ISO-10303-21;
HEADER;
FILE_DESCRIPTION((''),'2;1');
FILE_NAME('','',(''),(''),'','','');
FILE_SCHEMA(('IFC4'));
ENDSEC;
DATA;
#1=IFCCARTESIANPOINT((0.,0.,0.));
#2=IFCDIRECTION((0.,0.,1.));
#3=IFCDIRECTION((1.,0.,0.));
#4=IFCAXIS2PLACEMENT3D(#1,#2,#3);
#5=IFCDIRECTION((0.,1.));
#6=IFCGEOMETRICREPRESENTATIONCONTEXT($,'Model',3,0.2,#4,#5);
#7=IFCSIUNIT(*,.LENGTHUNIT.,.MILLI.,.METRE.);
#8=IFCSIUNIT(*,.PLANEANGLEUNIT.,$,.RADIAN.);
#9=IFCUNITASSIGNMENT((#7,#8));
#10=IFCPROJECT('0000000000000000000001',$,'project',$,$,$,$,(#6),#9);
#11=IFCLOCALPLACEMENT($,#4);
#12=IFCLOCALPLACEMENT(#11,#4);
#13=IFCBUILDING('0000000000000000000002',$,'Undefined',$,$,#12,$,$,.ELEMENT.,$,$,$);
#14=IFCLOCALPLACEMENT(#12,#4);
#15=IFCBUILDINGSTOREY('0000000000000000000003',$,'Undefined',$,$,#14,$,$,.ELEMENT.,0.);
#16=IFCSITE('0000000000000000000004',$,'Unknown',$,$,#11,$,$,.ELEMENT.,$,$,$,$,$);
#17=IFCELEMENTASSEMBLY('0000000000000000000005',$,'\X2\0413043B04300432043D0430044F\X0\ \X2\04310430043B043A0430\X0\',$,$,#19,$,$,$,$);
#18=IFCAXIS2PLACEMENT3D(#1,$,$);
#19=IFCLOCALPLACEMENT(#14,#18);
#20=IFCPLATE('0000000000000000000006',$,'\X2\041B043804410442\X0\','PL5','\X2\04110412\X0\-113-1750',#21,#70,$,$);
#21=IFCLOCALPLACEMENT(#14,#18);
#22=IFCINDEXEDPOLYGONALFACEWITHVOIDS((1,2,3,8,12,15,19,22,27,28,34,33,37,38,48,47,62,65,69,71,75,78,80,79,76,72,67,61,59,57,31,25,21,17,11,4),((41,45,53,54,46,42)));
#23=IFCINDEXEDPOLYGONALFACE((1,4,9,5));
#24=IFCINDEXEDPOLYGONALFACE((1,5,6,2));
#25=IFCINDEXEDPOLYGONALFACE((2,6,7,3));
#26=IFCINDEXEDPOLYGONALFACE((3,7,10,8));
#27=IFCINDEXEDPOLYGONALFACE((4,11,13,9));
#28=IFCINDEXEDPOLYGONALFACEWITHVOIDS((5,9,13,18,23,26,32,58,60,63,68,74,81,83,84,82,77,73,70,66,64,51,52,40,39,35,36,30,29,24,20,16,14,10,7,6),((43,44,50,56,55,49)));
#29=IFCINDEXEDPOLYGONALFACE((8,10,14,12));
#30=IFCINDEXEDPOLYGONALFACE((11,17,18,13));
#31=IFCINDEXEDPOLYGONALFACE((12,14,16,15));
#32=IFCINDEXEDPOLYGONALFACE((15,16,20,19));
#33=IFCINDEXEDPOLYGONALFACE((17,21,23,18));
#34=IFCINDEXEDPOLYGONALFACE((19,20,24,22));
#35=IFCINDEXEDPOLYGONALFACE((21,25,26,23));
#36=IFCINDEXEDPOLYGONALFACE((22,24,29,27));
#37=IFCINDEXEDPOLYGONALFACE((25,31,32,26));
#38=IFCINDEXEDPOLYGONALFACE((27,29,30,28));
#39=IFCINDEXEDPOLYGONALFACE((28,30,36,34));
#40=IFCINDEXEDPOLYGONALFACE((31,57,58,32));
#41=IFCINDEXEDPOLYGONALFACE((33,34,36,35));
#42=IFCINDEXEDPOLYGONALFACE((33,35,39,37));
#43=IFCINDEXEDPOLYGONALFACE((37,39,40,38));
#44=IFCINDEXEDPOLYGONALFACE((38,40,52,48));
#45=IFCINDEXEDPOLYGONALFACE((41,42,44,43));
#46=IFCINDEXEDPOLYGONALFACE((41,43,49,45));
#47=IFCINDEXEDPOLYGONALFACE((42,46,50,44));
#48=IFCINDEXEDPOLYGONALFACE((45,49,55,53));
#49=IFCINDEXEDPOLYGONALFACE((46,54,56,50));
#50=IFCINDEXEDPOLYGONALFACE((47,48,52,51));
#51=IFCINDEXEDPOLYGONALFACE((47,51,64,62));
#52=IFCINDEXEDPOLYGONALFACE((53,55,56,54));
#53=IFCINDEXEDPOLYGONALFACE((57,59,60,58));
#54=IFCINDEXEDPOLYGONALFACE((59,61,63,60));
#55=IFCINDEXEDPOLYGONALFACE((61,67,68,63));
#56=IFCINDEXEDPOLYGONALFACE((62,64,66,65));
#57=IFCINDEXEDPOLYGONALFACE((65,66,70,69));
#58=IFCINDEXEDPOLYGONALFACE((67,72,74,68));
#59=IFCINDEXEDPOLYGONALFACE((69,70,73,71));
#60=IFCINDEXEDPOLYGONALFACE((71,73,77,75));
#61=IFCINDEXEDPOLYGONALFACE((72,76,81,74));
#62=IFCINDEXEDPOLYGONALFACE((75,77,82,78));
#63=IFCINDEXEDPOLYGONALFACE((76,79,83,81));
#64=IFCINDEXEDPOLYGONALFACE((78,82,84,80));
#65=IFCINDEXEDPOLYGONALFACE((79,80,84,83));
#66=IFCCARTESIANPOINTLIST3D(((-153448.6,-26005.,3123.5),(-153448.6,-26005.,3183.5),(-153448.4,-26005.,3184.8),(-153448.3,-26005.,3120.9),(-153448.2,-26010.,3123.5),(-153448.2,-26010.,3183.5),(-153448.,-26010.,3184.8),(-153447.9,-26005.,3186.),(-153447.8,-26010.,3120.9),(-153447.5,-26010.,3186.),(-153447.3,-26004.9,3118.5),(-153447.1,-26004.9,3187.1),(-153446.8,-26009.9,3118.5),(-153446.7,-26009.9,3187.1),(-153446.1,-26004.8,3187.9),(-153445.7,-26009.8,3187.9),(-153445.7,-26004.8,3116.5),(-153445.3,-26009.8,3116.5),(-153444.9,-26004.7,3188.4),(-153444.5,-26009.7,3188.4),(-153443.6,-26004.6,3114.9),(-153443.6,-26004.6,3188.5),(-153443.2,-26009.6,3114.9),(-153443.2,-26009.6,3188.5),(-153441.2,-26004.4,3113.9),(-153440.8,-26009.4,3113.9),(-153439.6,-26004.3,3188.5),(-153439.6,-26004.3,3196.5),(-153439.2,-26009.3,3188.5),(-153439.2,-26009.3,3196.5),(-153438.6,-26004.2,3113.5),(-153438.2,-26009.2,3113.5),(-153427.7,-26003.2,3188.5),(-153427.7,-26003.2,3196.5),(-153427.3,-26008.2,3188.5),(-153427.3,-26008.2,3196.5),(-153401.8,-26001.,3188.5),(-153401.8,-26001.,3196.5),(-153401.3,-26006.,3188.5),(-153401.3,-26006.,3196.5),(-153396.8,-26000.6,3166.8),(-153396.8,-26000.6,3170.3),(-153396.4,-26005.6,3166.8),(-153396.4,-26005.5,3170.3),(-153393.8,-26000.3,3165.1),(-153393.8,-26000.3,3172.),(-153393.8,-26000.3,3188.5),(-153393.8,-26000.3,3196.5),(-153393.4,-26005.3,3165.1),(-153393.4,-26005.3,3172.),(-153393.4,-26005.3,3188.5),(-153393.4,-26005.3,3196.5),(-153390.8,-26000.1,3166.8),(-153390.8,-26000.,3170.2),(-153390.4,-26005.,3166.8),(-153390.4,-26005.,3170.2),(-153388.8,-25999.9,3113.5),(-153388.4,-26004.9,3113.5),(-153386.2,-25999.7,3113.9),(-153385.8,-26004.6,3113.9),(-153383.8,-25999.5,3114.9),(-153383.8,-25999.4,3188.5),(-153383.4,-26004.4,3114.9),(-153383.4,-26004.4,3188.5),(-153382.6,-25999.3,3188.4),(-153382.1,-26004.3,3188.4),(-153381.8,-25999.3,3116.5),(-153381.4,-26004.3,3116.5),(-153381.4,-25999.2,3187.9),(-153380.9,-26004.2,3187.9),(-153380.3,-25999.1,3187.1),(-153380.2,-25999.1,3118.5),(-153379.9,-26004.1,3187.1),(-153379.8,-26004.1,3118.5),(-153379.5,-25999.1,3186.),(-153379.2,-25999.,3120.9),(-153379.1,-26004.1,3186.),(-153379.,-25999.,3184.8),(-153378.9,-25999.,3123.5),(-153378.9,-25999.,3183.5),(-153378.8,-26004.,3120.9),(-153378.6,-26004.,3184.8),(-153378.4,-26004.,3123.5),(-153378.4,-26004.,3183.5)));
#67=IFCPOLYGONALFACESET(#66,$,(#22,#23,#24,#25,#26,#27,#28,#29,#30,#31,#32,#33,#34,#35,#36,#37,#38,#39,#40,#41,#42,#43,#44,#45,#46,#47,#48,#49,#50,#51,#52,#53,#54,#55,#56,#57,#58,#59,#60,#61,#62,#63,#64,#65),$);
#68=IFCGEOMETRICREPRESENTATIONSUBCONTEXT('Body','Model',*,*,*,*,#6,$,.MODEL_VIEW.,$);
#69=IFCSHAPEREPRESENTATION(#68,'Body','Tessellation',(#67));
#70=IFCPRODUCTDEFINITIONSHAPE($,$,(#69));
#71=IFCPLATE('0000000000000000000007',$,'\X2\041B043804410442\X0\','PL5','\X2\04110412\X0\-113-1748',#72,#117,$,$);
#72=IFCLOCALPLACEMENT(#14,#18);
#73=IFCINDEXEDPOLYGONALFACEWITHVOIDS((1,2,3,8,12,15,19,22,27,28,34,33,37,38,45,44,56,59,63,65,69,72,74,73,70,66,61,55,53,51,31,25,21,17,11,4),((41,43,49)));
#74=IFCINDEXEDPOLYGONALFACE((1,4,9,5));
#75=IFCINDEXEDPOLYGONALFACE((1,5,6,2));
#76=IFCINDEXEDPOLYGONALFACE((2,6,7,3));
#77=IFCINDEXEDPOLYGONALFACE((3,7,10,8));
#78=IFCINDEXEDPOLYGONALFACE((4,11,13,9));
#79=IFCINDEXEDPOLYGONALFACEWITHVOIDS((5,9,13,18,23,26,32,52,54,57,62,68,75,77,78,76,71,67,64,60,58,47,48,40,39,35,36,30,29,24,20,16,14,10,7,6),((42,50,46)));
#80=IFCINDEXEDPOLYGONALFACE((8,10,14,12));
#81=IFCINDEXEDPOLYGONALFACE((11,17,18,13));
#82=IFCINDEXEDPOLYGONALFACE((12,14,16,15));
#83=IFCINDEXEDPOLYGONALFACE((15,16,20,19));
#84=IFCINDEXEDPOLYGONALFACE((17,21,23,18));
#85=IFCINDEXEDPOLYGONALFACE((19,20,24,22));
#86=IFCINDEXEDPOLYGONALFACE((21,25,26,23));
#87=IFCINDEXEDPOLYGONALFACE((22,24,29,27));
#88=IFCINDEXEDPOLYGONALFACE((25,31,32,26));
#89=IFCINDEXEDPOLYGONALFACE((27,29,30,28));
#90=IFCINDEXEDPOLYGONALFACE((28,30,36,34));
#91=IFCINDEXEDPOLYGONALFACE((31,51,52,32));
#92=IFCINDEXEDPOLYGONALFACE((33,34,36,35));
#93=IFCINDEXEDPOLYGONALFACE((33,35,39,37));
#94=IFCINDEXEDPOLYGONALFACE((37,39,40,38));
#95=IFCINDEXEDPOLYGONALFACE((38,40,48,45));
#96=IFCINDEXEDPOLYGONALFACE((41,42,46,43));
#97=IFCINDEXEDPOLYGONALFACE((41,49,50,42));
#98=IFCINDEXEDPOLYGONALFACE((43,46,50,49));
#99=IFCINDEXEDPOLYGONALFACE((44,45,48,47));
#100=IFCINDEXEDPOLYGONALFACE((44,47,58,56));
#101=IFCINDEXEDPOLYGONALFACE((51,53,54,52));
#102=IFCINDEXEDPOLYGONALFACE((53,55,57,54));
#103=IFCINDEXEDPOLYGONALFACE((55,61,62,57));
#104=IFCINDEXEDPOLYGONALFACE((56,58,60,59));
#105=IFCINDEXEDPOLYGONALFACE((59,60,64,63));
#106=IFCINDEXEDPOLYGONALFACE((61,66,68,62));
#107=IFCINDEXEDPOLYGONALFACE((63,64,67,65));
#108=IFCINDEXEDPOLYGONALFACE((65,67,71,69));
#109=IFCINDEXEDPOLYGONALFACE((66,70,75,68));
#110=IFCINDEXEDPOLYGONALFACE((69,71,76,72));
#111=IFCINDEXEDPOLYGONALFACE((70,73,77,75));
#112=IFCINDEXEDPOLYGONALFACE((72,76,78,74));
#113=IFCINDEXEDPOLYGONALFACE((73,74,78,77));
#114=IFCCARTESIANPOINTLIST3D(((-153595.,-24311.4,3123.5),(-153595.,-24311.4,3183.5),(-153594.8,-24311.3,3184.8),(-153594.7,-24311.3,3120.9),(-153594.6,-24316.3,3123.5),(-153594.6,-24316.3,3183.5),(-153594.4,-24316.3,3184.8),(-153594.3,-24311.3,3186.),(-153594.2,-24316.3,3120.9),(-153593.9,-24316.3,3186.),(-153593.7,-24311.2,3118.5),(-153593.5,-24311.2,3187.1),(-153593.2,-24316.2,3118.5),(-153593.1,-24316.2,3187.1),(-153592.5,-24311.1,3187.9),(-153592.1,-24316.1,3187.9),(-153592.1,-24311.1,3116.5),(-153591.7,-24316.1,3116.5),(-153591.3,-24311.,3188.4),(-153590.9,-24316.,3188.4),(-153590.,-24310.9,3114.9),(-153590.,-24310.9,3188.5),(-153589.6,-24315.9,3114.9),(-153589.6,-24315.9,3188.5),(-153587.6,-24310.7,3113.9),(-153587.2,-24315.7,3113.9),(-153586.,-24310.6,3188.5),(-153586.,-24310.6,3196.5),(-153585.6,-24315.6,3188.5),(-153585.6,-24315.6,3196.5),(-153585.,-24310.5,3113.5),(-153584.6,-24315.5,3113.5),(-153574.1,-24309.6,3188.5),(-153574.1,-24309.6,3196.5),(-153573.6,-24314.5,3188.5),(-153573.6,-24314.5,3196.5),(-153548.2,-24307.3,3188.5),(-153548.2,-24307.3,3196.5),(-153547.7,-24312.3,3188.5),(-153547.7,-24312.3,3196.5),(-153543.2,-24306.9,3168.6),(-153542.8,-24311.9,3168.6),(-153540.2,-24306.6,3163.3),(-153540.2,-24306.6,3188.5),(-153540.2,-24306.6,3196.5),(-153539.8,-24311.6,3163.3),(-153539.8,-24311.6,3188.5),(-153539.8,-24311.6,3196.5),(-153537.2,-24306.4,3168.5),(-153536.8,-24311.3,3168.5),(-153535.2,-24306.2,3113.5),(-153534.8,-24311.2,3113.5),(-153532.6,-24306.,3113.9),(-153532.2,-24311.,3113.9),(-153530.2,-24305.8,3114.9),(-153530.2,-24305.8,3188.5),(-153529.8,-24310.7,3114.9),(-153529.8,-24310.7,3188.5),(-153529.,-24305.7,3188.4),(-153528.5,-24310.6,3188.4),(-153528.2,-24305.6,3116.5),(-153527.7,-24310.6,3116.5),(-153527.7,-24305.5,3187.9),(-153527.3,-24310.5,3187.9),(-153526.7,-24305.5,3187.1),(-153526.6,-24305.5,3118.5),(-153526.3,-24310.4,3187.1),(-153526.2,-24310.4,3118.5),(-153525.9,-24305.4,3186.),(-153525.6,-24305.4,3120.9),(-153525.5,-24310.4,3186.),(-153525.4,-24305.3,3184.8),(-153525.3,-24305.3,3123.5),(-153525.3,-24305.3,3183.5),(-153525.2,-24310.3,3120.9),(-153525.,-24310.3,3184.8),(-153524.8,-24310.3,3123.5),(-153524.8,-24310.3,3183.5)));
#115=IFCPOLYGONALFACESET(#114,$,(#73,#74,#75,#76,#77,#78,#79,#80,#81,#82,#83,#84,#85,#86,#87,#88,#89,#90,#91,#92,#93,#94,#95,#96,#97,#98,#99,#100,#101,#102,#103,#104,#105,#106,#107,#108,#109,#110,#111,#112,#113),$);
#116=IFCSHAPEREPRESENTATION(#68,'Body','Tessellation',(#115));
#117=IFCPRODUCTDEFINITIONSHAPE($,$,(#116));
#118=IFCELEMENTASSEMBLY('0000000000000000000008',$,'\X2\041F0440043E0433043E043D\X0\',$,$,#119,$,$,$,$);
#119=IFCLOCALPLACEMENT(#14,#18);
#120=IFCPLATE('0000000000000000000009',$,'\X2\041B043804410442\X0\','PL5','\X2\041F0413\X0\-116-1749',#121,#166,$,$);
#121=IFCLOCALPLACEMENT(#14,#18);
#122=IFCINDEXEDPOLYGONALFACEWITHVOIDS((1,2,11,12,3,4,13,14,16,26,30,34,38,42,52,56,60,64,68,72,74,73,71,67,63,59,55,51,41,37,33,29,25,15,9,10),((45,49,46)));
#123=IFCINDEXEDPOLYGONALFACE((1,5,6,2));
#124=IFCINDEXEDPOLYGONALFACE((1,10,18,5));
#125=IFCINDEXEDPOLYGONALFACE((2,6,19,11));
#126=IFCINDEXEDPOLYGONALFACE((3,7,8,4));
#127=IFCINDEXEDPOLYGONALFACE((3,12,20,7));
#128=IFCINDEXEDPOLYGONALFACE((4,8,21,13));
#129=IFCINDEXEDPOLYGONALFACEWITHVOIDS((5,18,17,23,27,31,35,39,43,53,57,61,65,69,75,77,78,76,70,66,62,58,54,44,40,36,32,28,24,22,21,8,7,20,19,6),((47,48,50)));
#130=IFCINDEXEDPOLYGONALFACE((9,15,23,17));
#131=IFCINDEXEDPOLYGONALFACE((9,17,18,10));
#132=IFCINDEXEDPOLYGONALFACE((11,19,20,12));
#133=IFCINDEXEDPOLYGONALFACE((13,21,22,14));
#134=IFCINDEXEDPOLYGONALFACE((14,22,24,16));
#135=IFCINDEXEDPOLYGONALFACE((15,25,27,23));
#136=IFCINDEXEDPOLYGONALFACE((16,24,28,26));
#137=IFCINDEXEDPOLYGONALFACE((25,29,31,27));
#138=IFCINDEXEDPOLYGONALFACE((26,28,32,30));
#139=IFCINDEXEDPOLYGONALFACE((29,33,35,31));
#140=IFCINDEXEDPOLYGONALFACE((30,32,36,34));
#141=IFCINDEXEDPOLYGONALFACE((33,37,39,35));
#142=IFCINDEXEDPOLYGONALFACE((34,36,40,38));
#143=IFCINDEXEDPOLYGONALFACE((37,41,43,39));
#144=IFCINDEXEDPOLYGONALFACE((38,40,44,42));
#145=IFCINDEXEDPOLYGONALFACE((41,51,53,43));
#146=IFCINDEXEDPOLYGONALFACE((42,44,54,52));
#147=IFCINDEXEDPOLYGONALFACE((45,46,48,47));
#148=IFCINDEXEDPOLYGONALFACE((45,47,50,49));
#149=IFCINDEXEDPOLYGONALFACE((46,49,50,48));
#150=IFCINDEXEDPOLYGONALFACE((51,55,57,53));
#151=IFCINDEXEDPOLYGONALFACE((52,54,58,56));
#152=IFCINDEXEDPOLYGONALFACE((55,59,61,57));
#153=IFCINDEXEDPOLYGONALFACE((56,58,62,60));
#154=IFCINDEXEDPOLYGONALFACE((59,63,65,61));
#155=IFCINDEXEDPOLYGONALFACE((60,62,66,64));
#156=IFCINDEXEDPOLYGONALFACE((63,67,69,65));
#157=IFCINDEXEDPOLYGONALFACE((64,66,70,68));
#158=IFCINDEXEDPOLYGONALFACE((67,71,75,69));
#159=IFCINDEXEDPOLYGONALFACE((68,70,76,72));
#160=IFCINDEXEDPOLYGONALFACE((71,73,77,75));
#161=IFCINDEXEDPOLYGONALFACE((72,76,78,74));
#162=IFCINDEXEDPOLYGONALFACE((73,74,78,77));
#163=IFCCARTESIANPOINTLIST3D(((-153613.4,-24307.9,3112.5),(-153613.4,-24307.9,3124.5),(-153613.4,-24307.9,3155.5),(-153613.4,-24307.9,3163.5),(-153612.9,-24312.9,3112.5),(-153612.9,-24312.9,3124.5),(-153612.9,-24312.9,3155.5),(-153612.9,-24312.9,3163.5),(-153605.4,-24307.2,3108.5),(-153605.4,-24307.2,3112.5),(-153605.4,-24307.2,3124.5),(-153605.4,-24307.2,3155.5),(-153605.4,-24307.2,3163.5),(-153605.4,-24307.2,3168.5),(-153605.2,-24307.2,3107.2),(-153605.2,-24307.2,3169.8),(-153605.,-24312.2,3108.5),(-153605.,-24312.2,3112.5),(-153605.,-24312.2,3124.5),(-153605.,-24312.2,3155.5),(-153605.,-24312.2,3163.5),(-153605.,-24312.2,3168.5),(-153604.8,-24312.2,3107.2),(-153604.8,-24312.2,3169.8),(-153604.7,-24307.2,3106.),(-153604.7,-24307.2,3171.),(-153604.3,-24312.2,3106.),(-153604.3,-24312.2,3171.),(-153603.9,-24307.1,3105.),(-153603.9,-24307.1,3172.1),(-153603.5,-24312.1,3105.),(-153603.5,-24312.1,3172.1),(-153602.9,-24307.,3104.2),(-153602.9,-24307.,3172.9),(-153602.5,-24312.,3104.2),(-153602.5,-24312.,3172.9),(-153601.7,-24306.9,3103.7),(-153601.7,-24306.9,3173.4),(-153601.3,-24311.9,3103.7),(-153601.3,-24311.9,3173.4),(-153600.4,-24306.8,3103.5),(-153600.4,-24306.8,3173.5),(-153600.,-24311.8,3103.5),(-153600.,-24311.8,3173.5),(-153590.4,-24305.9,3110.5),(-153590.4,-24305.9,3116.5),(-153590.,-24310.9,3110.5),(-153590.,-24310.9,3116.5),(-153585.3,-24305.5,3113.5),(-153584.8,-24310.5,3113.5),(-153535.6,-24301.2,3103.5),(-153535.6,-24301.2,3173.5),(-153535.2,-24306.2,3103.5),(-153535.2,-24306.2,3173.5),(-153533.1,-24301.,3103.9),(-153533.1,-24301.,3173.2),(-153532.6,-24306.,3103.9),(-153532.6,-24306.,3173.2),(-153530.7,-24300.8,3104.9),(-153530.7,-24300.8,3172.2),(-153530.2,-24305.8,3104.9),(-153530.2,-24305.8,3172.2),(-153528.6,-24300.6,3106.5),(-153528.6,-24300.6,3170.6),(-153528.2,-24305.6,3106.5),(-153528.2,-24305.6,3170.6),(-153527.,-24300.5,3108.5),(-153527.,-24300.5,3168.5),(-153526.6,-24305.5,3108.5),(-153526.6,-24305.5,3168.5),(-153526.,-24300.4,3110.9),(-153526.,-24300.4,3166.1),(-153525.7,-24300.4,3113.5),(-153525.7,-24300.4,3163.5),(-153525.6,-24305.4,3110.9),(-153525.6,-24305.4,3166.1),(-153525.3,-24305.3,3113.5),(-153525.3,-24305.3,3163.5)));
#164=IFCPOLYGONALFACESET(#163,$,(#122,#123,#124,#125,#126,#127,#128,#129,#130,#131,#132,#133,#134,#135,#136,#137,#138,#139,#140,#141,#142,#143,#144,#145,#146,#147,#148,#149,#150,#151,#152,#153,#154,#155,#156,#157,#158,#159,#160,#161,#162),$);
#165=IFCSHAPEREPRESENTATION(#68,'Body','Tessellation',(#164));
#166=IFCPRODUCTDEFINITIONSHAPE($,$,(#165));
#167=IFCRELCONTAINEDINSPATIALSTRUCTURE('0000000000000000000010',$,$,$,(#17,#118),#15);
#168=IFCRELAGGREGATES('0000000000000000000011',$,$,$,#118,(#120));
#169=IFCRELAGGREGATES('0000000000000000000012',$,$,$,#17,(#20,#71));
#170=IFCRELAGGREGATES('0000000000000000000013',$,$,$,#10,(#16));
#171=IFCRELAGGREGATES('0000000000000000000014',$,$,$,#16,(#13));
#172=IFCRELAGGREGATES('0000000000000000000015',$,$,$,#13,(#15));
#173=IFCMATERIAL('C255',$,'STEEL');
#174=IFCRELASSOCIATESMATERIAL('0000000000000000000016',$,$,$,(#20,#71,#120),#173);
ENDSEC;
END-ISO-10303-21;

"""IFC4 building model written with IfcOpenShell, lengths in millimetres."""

from ifc_helpers import new_model, si_unit, direction, frame, origin_with_axes, place, context, subcontext, project, spatial, line, arc, indexed_curve, outline, extrude, material, element, aggregate, save


model = new_model("IFC4")

# Units and contexts
model_context = context("Model", 3, precision=0.2, world=origin_with_axes(), true_north=direction((0.0, 1.0)))
body_context = subcontext(model_context, "Body", "Model", "MODEL_VIEW")
ifc_project = project(units=[si_unit("LENGTHUNIT", "METRE", prefix="MILLI"), si_unit("PLANEANGLEUNIT", "RADIAN")], contexts=[model_context])

# Site, building, storey
site_placement = place(None, origin_with_axes())
site = spatial("IfcSite", under=ifc_project, at=site_placement, Name="Unknown", CompositionType="ELEMENT")
building_placement = place(site_placement, origin_with_axes())
building = spatial("IfcBuilding", under=site, at=building_placement, Name="Undefined", CompositionType="ELEMENT")
storey_placement = place(building_placement, origin_with_axes())
storey = spatial("IfcBuildingStorey", under=building, at=storey_placement, Name="Undefined", CompositionType="ELEMENT", Elevation=0.0)

# Shared definitions
ifc_material_1 = material(Name="C255", Category="STEEL")

# Element assemblies, plates, voiding features
assembly_1_placement = place(storey_placement, frame((-153409.2, -26112.7, 3248.5), z_axis=(-0.996285, -0.086114, -0.000024), x_axis=(-0.086114, 0.996285, 0.0)))
assembly_1 = element("IfcElementAssembly", 1, at=assembly_1_placement, inside=storey, Name="Главная балка")
plate_1_placement = place(assembly_1_placement, frame((108.2, 135.0, -40.0), z_axis=(1.0, 0.000054, 0.0), x_axis=(0.0, -0.000054, 1.0)))
plate_1 = element("IfcPlate", 2, at=plate_1_placement, material=ifc_material_1, Name="Лист", Description="PL5", ObjectType="БВ-113-1750", context=body_context, shape_type="SolidModel", body=[
    extrude(outline(indexed_curve([(0.0, 10.0), (2.9, 2.9), (10.0, 0.0), (60.0, 0.0), (67.1, 2.9), (70.0, 10.0), (70.0, 70.0), (68.5, 73.5), (65.0, 75.0), (61.0, 75.0), (61.0, 83.0), (49.0, 83.0), (49.0, 75.0), (23.0, 75.0), (23.0, 83.0), (15.0, 83.0), (15.0, 75.0), (5.0, 75.0), (1.5, 73.5), (0.0, 70.0)], segments=[arc(1, 2, 3), line(3, 4), arc(4, 5, 6), line(6, 7), arc(7, 8, 9), line(9, 10, 11, 12, 13, 14, 15, 16, 17, 18), arc(18, 19, 20), line(20, 1)])), frame((0.0, 0.0, 2.5), z_axis=(0.0, 0.0, 1.0), x_axis=(1.0, 0.0, 0.0)), (0.0, 0.0, -1.0), 5.0),
])
voiding_feature_1_placement = place(plate_1_placement, frame((15.0, 55.0, 10.0), z_axis=(0.007997, -0.999968, -0.000026), x_axis=(0.0, 0.000026, -1.0)))
element("IfcVoidingFeature", 3, at=voiding_feature_1_placement, cuts=plate_1, Name="Балка", ObjectType="(?)", PredefinedType="HOLE", context=body_context, shape_type="SolidModel", body=[
    extrude(outline(indexed_curve([(1.7, -3.0), (3.5, 0.0), (1.7, 3.0), (-1.7, 3.0), (-3.5, 0.0), (-1.7, -3.0)], segments=[line(1, 2, 3, 4, 5, 6, 1)])), frame((0.0, 0.0, 0.0), z_axis=(-1.0, 0.0, 0.0), x_axis=(0.0, 0.0, 1.0)), (0.0, 0.0, -1.0), 20.0),
])
plate_2_placement = place(assembly_1_placement, frame((1808.2, 135.0, -40.0), z_axis=(1.0, 0.000054, 0.0), x_axis=(0.0, -0.000054, 1.0)))
plate_2 = element("IfcPlate", 4, at=plate_2_placement, material=ifc_material_1, Name="Лист", Description="PL5", ObjectType="БВ-113-1748", context=body_context, shape_type="SolidModel", body=[
    extrude(outline(indexed_curve([(0.0, 10.0), (2.9, 2.9), (10.0, 0.0), (60.0, 0.0), (67.1, 2.9), (70.0, 10.0), (70.0, 70.0), (68.5, 73.5), (65.0, 75.0), (61.0, 75.0), (61.0, 83.0), (49.0, 83.0), (49.0, 75.0), (23.0, 75.0), (23.0, 83.0), (15.0, 83.0), (15.0, 75.0), (5.0, 75.0), (1.5, 73.5), (0.0, 70.0)], segments=[arc(1, 2, 3), line(3, 4), arc(4, 5, 6), line(6, 7), arc(7, 8, 9), line(9, 10, 11, 12, 13, 14, 15, 16, 17, 18), arc(18, 19, 20), line(20, 1)])), frame((0.0, 0.0, 2.5), z_axis=(0.0, 0.0, 1.0), x_axis=(1.0, 0.0, 0.0)), (0.0, 0.0, -1.0), 5.0),
])
voiding_feature_2_placement = place(plate_2_placement, frame((15.0, 55.0, 10.0), z_axis=(0.007997, -0.999968, -0.000026), x_axis=(0.0, 0.000026, -1.0)))
element("IfcVoidingFeature", 5, at=voiding_feature_2_placement, cuts=plate_2, Name="Балка", ObjectType="(?)", PredefinedType="HOLE", context=body_context, shape_type="SolidModel", body=[
    extrude(outline(indexed_curve([(0.0, -3.0), (5.2, 0.0), (0.0, 3.0)], segments=[line(1, 2, 3, 1)])), frame((0.0, 0.0, 0.0), z_axis=(-1.0, 0.0, 0.0), x_axis=(0.0, 0.0, 1.0)), (0.0, 0.0, -1.0), 20.0),
])
assembly_2_placement = place(storey_placement, frame((-153645.0, -24313.2, 533.0), z_axis=(0.086114, -0.996285, 0.0), x_axis=(0.0, 0.0, 1.0)))
assembly_2 = element("IfcElementAssembly", 6, at=assembly_2_placement, inside=storey, Name="Прогон")
plate_3_placement = place(assembly_2_placement, frame((2640.5, -120.0, 0.0), z_axis=(0.0, -0.000057, -1.0), x_axis=(-1.0, 0.000024, 0.0)))
plate_3 = element("IfcPlate", 7, at=plate_3_placement, material=ifc_material_1, Name="Лист", Description="PL5", ObjectType="ПГ-116-1749", context=body_context, shape_type="SolidModel", body=[
    extrude(outline(indexed_curve([(0.0, 10.0), (2.9, 2.9), (10.0, 0.0), (60.0, 0.0), (67.1, 2.9), (70.0, 10.0), (70.0, 75.0), (68.5, 78.5), (65.0, 80.0), (61.0, 80.0), (61.0, 88.0), (49.0, 88.0), (49.0, 80.0), (18.0, 80.0), (18.0, 88.0), (10.0, 88.0), (10.0, 80.0), (5.0, 80.0), (1.5, 78.5), (0.0, 75.0)], segments=[arc(1, 2, 3), line(3, 4), arc(4, 5, 6), line(6, 7), arc(7, 8, 9), line(9, 10, 11, 12, 13, 14, 15, 16, 17, 18), arc(18, 19, 20), line(20, 1)])), frame((0.0, 0.0, 2.5), z_axis=(0.0, 0.0, 1.0), x_axis=(1.0, 0.0, 0.0)), (0.0, 0.0, -1.0), 5.0),
])
voiding_feature_3_placement = place(plate_3_placement, frame((60.0, 65.0, 6.0), z_axis=(-0.000054, -1.0, 0.000034), x_axis=(0.0, -0.000034, -1.0)))
element("IfcVoidingFeature", 8, at=voiding_feature_3_placement, cuts=plate_3, Name="Балка", ObjectType="(?)", PredefinedType="HOLE", context=body_context, shape_type="SolidModel", body=[
    extrude(outline(indexed_curve([(0.0, -3.0), (5.2, 0.0), (0.0, 3.0)], segments=[line(1, 2, 3, 1)])), frame((0.0, 0.0, 0.0), z_axis=(-1.0, 0.0, 0.0), x_axis=(0.0, 0.0, 1.0)), (0.0, 0.0, -1.0), 12.0),
])

aggregate(assembly_2, [plate_3])
aggregate(assembly_1, [plate_1, plate_2])

save(model, "model.ifc")
